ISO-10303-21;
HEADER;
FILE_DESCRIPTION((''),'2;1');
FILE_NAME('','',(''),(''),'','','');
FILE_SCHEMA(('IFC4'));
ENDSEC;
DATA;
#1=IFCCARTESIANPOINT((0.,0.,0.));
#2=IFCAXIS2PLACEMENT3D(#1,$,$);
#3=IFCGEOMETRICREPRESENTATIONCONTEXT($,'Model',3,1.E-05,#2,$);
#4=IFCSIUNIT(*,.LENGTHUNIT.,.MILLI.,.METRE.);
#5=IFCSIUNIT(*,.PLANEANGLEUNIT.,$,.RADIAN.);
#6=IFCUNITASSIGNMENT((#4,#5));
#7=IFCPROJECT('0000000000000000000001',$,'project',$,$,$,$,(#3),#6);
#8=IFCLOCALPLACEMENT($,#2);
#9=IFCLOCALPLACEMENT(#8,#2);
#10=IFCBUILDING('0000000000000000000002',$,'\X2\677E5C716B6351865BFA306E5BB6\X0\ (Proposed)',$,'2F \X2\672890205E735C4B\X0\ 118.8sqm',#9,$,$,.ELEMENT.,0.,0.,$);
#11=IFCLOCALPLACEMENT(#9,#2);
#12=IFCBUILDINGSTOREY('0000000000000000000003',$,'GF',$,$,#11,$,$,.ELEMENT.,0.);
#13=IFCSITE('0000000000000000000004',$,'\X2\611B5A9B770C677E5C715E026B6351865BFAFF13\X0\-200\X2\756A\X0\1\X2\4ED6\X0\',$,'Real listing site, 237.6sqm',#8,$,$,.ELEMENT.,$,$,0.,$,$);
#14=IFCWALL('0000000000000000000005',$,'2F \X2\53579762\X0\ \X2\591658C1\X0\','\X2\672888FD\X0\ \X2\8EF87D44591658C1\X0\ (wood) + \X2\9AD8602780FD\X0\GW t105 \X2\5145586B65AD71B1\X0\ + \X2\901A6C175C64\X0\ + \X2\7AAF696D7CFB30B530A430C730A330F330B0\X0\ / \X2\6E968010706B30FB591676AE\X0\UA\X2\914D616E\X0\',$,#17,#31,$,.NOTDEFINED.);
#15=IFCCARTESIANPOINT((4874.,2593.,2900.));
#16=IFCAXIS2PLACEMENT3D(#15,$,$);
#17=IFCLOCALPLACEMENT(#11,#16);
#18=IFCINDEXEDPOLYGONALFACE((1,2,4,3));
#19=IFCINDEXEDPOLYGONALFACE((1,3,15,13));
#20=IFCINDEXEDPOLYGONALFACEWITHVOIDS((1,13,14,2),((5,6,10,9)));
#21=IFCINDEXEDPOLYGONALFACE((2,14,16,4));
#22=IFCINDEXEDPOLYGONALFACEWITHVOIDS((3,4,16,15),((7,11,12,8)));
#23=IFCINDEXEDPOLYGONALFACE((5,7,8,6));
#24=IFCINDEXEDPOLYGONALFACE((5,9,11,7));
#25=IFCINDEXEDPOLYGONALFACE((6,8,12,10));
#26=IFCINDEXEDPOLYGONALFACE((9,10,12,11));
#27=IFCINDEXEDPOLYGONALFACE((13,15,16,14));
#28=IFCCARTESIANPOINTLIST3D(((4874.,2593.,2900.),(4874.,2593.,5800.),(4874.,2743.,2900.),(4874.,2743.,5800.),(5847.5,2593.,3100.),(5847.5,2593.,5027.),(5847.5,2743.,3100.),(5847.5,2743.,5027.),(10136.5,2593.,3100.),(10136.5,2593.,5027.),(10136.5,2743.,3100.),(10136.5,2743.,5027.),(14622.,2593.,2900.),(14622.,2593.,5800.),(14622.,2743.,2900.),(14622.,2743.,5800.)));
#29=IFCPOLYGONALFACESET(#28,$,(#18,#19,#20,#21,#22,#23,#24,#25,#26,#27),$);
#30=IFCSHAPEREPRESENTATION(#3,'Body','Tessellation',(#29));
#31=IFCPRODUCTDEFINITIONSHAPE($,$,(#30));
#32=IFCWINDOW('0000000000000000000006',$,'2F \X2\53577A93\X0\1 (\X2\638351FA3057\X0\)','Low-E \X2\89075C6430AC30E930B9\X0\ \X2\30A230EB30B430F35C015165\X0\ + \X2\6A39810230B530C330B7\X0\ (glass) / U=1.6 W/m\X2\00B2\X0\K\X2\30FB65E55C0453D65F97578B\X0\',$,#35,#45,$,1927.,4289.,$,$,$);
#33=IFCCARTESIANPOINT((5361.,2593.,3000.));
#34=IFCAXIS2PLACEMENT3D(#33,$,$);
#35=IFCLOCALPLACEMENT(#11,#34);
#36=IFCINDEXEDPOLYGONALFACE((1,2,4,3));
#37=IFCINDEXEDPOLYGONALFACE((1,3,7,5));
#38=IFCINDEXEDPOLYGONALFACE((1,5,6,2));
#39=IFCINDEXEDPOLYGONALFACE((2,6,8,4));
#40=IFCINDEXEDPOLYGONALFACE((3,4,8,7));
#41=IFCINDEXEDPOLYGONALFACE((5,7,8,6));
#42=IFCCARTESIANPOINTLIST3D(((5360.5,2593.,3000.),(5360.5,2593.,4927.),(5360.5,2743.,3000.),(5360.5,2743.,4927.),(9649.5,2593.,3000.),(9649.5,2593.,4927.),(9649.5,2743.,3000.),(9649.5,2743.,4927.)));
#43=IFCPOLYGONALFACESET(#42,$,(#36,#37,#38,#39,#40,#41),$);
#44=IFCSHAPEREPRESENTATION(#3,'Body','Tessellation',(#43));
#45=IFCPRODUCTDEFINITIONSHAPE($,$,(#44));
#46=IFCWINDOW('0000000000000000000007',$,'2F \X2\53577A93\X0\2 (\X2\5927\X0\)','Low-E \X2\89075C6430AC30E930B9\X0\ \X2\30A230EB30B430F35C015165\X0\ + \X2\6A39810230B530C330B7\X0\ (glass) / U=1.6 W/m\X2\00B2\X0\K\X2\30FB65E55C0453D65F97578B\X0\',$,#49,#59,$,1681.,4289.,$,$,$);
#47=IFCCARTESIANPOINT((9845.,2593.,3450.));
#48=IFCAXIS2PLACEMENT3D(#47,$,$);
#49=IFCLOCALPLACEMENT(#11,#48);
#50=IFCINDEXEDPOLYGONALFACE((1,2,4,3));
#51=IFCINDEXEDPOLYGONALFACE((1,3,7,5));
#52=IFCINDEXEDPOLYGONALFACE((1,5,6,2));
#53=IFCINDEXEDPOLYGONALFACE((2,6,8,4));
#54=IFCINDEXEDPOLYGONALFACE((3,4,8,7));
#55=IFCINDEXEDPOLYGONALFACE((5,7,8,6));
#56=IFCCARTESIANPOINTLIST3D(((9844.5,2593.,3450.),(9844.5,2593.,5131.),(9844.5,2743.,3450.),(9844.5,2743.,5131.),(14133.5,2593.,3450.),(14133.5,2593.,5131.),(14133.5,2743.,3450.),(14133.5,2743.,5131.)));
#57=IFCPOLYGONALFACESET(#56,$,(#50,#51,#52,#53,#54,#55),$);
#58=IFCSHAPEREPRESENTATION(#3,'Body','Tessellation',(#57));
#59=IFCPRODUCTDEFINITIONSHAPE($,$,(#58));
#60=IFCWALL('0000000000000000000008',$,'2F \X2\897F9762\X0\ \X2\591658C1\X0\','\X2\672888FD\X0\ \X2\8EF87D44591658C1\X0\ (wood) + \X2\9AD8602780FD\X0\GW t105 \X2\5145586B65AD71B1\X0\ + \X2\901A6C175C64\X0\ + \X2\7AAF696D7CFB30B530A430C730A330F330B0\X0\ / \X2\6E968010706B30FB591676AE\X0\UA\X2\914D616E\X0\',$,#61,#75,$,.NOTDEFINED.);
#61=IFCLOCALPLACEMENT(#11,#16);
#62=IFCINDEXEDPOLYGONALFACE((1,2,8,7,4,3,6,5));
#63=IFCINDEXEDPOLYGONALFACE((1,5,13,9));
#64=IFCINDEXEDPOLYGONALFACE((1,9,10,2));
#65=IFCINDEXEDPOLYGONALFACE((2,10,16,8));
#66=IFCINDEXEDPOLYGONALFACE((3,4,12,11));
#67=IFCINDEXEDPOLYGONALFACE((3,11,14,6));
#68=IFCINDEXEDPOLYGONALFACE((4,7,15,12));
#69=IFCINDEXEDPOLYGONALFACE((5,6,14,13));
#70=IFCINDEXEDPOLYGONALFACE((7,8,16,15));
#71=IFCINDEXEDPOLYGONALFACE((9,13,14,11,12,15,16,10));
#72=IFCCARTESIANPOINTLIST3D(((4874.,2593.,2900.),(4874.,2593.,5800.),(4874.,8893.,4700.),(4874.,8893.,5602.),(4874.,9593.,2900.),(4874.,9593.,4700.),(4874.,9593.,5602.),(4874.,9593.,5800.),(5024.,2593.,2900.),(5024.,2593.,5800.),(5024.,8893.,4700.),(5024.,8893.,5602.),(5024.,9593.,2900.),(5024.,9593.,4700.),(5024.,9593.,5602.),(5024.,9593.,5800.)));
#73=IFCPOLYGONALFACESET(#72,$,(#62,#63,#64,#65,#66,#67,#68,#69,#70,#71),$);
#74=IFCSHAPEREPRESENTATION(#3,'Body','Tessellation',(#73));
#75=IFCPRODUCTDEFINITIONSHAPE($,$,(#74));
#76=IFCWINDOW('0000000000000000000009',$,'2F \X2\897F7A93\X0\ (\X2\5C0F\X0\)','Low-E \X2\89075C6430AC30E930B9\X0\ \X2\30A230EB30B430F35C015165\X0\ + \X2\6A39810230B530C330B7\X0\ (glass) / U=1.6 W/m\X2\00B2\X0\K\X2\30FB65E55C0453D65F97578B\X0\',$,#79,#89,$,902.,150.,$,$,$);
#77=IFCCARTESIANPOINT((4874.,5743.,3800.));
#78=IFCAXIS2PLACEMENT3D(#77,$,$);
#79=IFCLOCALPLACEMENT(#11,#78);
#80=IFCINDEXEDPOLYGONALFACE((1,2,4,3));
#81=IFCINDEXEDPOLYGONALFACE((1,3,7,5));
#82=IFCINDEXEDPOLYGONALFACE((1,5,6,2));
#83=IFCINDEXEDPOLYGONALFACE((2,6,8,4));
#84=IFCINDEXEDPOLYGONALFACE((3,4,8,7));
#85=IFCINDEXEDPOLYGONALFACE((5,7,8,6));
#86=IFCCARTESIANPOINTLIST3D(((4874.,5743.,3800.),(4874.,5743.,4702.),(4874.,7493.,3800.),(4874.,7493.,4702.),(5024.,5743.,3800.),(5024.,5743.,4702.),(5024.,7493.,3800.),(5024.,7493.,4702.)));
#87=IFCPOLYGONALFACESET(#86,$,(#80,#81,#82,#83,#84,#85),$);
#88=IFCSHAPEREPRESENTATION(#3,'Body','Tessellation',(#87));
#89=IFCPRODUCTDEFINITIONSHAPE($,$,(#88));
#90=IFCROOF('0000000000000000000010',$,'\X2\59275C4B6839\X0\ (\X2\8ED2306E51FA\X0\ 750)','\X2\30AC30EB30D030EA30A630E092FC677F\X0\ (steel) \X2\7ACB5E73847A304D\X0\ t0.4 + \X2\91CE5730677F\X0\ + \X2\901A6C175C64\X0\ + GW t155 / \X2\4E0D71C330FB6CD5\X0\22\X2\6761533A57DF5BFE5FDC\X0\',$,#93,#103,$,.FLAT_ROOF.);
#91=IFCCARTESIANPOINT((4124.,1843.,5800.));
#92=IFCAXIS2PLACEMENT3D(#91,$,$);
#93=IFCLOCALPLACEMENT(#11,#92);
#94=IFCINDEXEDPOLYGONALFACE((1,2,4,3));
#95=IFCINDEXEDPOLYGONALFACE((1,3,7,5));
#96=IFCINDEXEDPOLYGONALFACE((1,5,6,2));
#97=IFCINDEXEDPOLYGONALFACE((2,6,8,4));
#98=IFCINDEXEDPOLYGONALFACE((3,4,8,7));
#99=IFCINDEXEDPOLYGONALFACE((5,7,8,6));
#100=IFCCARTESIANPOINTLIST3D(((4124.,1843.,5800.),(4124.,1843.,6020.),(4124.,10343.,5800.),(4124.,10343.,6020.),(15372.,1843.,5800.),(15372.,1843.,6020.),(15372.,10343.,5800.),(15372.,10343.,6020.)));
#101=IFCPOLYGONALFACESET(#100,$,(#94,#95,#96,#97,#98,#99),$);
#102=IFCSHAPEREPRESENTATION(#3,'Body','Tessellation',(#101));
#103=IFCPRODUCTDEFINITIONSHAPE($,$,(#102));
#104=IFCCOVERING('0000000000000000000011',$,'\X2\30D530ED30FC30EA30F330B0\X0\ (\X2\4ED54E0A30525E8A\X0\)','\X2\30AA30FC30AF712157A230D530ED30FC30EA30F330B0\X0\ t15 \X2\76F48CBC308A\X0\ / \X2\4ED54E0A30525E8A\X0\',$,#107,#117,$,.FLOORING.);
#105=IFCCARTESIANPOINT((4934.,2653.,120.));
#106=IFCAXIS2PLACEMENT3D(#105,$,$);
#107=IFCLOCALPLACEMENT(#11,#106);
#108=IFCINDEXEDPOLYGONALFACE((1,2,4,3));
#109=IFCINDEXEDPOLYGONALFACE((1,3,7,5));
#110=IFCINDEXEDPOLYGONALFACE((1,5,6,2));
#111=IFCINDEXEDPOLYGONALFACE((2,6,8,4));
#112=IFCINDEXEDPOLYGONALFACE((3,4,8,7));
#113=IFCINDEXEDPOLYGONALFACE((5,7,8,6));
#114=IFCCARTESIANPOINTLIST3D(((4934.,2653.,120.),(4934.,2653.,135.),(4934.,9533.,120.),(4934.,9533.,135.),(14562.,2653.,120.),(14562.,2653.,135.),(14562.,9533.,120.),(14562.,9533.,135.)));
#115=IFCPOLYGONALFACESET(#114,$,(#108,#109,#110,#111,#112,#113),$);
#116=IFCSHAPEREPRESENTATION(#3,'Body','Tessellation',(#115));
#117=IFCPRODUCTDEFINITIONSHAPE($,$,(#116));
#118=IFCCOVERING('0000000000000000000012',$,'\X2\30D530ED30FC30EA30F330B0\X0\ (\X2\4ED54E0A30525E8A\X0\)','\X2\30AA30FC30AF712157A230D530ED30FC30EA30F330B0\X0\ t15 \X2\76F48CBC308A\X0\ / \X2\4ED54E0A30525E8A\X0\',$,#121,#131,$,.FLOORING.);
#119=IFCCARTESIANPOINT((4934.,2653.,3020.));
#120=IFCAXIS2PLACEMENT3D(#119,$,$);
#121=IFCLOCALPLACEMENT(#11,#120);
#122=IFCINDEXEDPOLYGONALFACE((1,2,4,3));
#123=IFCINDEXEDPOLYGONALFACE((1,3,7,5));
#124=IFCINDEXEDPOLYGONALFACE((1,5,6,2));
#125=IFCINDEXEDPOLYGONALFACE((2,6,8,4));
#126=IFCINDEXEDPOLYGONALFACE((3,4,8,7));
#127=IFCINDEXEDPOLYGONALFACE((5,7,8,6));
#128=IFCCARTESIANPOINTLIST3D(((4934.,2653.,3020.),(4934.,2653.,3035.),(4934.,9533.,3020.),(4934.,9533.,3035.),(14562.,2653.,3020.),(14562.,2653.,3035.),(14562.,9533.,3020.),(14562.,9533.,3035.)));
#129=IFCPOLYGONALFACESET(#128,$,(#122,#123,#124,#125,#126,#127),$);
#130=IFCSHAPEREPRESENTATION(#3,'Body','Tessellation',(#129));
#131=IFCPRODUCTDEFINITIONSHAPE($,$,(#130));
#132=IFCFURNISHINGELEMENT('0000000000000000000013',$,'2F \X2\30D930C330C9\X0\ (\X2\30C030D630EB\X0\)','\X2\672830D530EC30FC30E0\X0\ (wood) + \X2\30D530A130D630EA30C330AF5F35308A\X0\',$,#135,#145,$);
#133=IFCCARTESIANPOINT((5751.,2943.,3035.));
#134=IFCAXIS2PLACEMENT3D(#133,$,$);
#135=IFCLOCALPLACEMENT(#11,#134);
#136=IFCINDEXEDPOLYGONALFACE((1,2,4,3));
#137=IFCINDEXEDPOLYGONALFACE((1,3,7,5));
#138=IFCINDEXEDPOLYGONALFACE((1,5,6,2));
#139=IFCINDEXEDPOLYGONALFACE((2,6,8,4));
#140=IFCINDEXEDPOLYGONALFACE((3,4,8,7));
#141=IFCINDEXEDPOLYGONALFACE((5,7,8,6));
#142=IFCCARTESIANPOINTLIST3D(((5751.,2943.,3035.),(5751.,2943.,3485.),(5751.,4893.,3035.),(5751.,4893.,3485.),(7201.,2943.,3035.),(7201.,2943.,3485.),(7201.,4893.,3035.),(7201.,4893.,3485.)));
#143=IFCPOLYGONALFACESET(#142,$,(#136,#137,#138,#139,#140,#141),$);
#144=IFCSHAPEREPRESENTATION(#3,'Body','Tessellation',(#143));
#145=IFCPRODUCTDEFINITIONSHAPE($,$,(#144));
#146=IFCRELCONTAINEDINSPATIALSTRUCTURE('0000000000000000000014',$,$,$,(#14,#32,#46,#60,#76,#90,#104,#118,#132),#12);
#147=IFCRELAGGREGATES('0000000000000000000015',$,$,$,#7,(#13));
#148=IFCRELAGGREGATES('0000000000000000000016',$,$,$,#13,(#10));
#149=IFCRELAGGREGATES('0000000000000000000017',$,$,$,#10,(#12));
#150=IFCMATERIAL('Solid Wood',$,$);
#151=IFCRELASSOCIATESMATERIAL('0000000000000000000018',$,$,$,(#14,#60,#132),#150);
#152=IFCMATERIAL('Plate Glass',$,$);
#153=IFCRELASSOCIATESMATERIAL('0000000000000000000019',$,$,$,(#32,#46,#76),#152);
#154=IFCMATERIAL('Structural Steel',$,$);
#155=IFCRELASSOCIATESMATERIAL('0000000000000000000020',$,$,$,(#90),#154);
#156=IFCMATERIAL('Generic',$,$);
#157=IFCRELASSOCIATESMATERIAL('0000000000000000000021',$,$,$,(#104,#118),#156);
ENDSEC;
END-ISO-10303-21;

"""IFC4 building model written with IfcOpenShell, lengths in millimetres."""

from ifc_helpers import new_model, si_unit, frame, frame_2d, origin, place, context, project, spatial, rectangle, extrude, material, element, fill, save


model = new_model("IFC4")

# Units and contexts
model_context = context("Model", 3, precision=1e-05, world=origin())
ifc_project = project(units=[si_unit("LENGTHUNIT", "METRE", prefix="MILLI"), si_unit("PLANEANGLEUNIT", "RADIAN")], contexts=[model_context])

# Site, building, storey
site_placement = place(None, origin())
site = spatial("IfcSite", under=ifc_project, at=site_placement, Name="愛媛県松山市正円寺３-200番1他", ObjectType="Real listing site, 237.6sqm", CompositionType="ELEMENT", RefElevation=0.0)
building_placement = place(site_placement, origin())
building = spatial("IfcBuilding", under=site, at=building_placement, Name="松山正円寺の家 (Proposed)", ObjectType="2F 木造平屋 118.8sqm", CompositionType="ELEMENT", ElevationOfRefHeight=0.0, ElevationOfTerrain=0.0)
storey_placement = place(building_placement, origin())
storey = spatial("IfcBuildingStorey", under=building, at=storey_placement, Name="GF", CompositionType="ELEMENT", Elevation=0.0)

# Shared definitions
ifc_material_1 = material(Name="Solid Wood")

# Shared definitions
ifc_material_2 = material(Name="Plate Glass")

# Wall, openings, windows
wall_1_placement = place(storey_placement, frame((4874.0, 2593.0, 2900.0)))
wall_1 = element("IfcWall", 1, at=wall_1_placement, inside=storey, material=ifc_material_1, Name="2F 南面 外壁", Description="木製 軸組外壁 (wood) + 高性能GW t105 充填断熱 + 通気層 + 窯業系サイディング / 準耐火・外皮UA配慮", PredefinedType="NOTDEFINED", context=model_context, shape_type="SweptSolid", body=[
    extrude(rectangle(XDim=9748.0, YDim=150.0, at=frame_2d((4874.0, 75.0))), frame((4874.0, 2593.0, 2900.0)), (0.0, 0.0, 1.0), 2900.0),
])
opening_1_placement = place(storey_placement, frame((5361.0, 2593.0, 3000.0)))
opening_1 = element("IfcOpeningElement", 2, at=opening_1_placement, cuts=wall_1, PredefinedType="NOTDEFINED", context=model_context, shape_type="SweptSolid", body=[
    extrude(rectangle(XDim=4289.0, YDim=150.0, at=frame_2d((2144.0, 75.0))), frame((5361.0, 2593.0, 3000.0)), (0.0, 0.0, 1.0), 1927.0),
])
opening_2_placement = place(storey_placement, frame((9845.0, 2593.0, 3450.0)))
opening_2 = element("IfcOpeningElement", 3, at=opening_2_placement, cuts=wall_1, PredefinedType="NOTDEFINED", context=model_context, shape_type="SweptSolid", body=[
    extrude(rectangle(XDim=4289.0, YDim=150.0, at=frame_2d((2144.0, 75.0))), frame((9845.0, 2593.0, 3450.0)), (0.0, 0.0, 1.0), 1681.0),
])
window_1_placement = place(storey_placement, frame((5361.0, 2593.0, 3000.0)))
window_1 = element("IfcWindow", 4, at=window_1_placement, inside=storey, material=ifc_material_2, Name="2F 南窓1 (掃出し)", Description="Low-E 複層ガラス アルゴン封入 + 樹脂サッシ (glass) / U=1.6 W/m²K・日射取得型", OverallHeight=1927.0, OverallWidth=4289.0, context=model_context, shape_type="SweptSolid", body=[
    extrude(rectangle(XDim=4289.0, YDim=150.0, at=frame_2d((2144.0, 75.0))), frame((5361.0, 2593.0, 3000.0)), (0.0, 0.0, 1.0), 1927.0),
])
fill(opening_1, window_1)
window_2_placement = place(storey_placement, frame((9845.0, 2593.0, 3450.0)))
window_2 = element("IfcWindow", 5, at=window_2_placement, inside=storey, material=ifc_material_2, Name="2F 南窓2 (大)", Description="Low-E 複層ガラス アルゴン封入 + 樹脂サッシ (glass) / U=1.6 W/m²K・日射取得型", OverallHeight=1681.0, OverallWidth=4289.0, context=model_context, shape_type="SweptSolid", body=[
    extrude(rectangle(XDim=4289.0, YDim=150.0, at=frame_2d((2144.0, 75.0))), frame((9845.0, 2593.0, 3450.0)), (0.0, 0.0, 1.0), 1681.0),
])
fill(opening_2, window_2)

# Wall, opening, window
wall_2_placement = place(storey_placement, frame((4874.0, 2593.0, 2900.0)))
wall_2 = element("IfcWall", 6, at=wall_2_placement, inside=storey, material=ifc_material_1, Name="2F 西面 外壁", Description="木製 軸組外壁 (wood) + 高性能GW t105 充填断熱 + 通気層 + 窯業系サイディング / 準耐火・外皮UA配慮", PredefinedType="NOTDEFINED", context=model_context, shape_type="SweptSolid", body=[
    extrude(rectangle(XDim=150.0, YDim=7000.0, at=frame_2d((75.0, 3500.0))), frame((4874.0, 2593.0, 2900.0)), (0.0, 0.0, 1.0), 2900.0),
])
opening_3_placement = place(storey_placement, frame((4874.0, 5743.0, 3800.0)))
opening_3 = element("IfcOpeningElement", 7, at=opening_3_placement, cuts=wall_2, PredefinedType="NOTDEFINED", context=model_context, shape_type="SweptSolid", body=[
    extrude(rectangle(XDim=150.0, YDim=1750.0, at=frame_2d((75.0, 875.0))), frame((4874.0, 5743.0, 3800.0)), (0.0, 0.0, 1.0), 902.0),
])
window_3_placement = place(storey_placement, frame((4874.0, 5743.0, 3800.0)))
window_3 = element("IfcWindow", 8, at=window_3_placement, inside=storey, material=ifc_material_2, Name="2F 西窓 (小)", Description="Low-E 複層ガラス アルゴン封入 + 樹脂サッシ (glass) / U=1.6 W/m²K・日射取得型", OverallHeight=902.0, OverallWidth=150.0, context=model_context, shape_type="SweptSolid", body=[
    extrude(rectangle(XDim=150.0, YDim=1750.0, at=frame_2d((75.0, 875.0))), frame((4874.0, 5743.0, 3800.0)), (0.0, 0.0, 1.0), 902.0),
])
fill(opening_3, window_3)

# Roof
ifc_material_3 = material(Name="Structural Steel")
roof_placement = place(storey_placement, frame((4124.0, 1843.0, 5800.0)))
element("IfcRoof", 9, at=roof_placement, inside=storey, material=ifc_material_3, Name="大屋根 (軒の出 750)", Description="ガルバリウム鋼板 (steel) 立平葺き t0.4 + 野地板 + 通気層 + GW t155 / 不燃・法22条区域対応", PredefinedType="FLAT_ROOF", context=model_context, shape_type="SweptSolid", body=[
    extrude(rectangle(XDim=11248.0, YDim=8500.0, at=frame_2d((5624.0, 4250.0))), frame((4124.0, 1843.0, 5800.0)), (0.0, 0.0, 1.0), 220.0),
])

# Coverings
ifc_material_4 = material(Name="Generic")
covering_1_placement = place(storey_placement, frame((4934.0, 2653.0, 120.0)))
element("IfcCovering", 10, at=covering_1_placement, inside=storey, material=ifc_material_4, Name="フローリング (仕上げ床)", Description="オーク無垢フローリング t15 直貼り / 仕上げ床", PredefinedType="FLOORING", context=model_context, shape_type="SweptSolid", body=[
    extrude(rectangle(XDim=9628.0, YDim=6880.0, at=frame_2d((4814.0, 3440.0))), frame((4934.0, 2653.0, 120.0)), (0.0, 0.0, 1.0), 15.0),
])
covering_2_placement = place(storey_placement, frame((4934.0, 2653.0, 3020.0)))
element("IfcCovering", 11, at=covering_2_placement, inside=storey, material=ifc_material_4, Name="フローリング (仕上げ床)", Description="オーク無垢フローリング t15 直貼り / 仕上げ床", PredefinedType="FLOORING", context=model_context, shape_type="SweptSolid", body=[
    extrude(rectangle(XDim=9628.0, YDim=6880.0, at=frame_2d((4814.0, 3440.0))), frame((4934.0, 2653.0, 3020.0)), (0.0, 0.0, 1.0), 15.0),
])

# Furnishing element
furnishing_placement = place(storey_placement, frame((5751.0, 2943.0, 3035.0)))
element("IfcFurnishingElement", 12, at=furnishing_placement, inside=storey, material=ifc_material_1, Name="2F ベッド (ダブル)", Description="木フレーム (wood) + ファブリック張り", context=model_context, shape_type="SweptSolid", body=[
    extrude(rectangle(XDim=1450.0, YDim=1950.0, at=frame_2d((725.0, 975.0))), frame((5751.0, 2943.0, 3035.0)), (0.0, 0.0, 1.0), 450.0),
])

save(model, "model.ifc")
